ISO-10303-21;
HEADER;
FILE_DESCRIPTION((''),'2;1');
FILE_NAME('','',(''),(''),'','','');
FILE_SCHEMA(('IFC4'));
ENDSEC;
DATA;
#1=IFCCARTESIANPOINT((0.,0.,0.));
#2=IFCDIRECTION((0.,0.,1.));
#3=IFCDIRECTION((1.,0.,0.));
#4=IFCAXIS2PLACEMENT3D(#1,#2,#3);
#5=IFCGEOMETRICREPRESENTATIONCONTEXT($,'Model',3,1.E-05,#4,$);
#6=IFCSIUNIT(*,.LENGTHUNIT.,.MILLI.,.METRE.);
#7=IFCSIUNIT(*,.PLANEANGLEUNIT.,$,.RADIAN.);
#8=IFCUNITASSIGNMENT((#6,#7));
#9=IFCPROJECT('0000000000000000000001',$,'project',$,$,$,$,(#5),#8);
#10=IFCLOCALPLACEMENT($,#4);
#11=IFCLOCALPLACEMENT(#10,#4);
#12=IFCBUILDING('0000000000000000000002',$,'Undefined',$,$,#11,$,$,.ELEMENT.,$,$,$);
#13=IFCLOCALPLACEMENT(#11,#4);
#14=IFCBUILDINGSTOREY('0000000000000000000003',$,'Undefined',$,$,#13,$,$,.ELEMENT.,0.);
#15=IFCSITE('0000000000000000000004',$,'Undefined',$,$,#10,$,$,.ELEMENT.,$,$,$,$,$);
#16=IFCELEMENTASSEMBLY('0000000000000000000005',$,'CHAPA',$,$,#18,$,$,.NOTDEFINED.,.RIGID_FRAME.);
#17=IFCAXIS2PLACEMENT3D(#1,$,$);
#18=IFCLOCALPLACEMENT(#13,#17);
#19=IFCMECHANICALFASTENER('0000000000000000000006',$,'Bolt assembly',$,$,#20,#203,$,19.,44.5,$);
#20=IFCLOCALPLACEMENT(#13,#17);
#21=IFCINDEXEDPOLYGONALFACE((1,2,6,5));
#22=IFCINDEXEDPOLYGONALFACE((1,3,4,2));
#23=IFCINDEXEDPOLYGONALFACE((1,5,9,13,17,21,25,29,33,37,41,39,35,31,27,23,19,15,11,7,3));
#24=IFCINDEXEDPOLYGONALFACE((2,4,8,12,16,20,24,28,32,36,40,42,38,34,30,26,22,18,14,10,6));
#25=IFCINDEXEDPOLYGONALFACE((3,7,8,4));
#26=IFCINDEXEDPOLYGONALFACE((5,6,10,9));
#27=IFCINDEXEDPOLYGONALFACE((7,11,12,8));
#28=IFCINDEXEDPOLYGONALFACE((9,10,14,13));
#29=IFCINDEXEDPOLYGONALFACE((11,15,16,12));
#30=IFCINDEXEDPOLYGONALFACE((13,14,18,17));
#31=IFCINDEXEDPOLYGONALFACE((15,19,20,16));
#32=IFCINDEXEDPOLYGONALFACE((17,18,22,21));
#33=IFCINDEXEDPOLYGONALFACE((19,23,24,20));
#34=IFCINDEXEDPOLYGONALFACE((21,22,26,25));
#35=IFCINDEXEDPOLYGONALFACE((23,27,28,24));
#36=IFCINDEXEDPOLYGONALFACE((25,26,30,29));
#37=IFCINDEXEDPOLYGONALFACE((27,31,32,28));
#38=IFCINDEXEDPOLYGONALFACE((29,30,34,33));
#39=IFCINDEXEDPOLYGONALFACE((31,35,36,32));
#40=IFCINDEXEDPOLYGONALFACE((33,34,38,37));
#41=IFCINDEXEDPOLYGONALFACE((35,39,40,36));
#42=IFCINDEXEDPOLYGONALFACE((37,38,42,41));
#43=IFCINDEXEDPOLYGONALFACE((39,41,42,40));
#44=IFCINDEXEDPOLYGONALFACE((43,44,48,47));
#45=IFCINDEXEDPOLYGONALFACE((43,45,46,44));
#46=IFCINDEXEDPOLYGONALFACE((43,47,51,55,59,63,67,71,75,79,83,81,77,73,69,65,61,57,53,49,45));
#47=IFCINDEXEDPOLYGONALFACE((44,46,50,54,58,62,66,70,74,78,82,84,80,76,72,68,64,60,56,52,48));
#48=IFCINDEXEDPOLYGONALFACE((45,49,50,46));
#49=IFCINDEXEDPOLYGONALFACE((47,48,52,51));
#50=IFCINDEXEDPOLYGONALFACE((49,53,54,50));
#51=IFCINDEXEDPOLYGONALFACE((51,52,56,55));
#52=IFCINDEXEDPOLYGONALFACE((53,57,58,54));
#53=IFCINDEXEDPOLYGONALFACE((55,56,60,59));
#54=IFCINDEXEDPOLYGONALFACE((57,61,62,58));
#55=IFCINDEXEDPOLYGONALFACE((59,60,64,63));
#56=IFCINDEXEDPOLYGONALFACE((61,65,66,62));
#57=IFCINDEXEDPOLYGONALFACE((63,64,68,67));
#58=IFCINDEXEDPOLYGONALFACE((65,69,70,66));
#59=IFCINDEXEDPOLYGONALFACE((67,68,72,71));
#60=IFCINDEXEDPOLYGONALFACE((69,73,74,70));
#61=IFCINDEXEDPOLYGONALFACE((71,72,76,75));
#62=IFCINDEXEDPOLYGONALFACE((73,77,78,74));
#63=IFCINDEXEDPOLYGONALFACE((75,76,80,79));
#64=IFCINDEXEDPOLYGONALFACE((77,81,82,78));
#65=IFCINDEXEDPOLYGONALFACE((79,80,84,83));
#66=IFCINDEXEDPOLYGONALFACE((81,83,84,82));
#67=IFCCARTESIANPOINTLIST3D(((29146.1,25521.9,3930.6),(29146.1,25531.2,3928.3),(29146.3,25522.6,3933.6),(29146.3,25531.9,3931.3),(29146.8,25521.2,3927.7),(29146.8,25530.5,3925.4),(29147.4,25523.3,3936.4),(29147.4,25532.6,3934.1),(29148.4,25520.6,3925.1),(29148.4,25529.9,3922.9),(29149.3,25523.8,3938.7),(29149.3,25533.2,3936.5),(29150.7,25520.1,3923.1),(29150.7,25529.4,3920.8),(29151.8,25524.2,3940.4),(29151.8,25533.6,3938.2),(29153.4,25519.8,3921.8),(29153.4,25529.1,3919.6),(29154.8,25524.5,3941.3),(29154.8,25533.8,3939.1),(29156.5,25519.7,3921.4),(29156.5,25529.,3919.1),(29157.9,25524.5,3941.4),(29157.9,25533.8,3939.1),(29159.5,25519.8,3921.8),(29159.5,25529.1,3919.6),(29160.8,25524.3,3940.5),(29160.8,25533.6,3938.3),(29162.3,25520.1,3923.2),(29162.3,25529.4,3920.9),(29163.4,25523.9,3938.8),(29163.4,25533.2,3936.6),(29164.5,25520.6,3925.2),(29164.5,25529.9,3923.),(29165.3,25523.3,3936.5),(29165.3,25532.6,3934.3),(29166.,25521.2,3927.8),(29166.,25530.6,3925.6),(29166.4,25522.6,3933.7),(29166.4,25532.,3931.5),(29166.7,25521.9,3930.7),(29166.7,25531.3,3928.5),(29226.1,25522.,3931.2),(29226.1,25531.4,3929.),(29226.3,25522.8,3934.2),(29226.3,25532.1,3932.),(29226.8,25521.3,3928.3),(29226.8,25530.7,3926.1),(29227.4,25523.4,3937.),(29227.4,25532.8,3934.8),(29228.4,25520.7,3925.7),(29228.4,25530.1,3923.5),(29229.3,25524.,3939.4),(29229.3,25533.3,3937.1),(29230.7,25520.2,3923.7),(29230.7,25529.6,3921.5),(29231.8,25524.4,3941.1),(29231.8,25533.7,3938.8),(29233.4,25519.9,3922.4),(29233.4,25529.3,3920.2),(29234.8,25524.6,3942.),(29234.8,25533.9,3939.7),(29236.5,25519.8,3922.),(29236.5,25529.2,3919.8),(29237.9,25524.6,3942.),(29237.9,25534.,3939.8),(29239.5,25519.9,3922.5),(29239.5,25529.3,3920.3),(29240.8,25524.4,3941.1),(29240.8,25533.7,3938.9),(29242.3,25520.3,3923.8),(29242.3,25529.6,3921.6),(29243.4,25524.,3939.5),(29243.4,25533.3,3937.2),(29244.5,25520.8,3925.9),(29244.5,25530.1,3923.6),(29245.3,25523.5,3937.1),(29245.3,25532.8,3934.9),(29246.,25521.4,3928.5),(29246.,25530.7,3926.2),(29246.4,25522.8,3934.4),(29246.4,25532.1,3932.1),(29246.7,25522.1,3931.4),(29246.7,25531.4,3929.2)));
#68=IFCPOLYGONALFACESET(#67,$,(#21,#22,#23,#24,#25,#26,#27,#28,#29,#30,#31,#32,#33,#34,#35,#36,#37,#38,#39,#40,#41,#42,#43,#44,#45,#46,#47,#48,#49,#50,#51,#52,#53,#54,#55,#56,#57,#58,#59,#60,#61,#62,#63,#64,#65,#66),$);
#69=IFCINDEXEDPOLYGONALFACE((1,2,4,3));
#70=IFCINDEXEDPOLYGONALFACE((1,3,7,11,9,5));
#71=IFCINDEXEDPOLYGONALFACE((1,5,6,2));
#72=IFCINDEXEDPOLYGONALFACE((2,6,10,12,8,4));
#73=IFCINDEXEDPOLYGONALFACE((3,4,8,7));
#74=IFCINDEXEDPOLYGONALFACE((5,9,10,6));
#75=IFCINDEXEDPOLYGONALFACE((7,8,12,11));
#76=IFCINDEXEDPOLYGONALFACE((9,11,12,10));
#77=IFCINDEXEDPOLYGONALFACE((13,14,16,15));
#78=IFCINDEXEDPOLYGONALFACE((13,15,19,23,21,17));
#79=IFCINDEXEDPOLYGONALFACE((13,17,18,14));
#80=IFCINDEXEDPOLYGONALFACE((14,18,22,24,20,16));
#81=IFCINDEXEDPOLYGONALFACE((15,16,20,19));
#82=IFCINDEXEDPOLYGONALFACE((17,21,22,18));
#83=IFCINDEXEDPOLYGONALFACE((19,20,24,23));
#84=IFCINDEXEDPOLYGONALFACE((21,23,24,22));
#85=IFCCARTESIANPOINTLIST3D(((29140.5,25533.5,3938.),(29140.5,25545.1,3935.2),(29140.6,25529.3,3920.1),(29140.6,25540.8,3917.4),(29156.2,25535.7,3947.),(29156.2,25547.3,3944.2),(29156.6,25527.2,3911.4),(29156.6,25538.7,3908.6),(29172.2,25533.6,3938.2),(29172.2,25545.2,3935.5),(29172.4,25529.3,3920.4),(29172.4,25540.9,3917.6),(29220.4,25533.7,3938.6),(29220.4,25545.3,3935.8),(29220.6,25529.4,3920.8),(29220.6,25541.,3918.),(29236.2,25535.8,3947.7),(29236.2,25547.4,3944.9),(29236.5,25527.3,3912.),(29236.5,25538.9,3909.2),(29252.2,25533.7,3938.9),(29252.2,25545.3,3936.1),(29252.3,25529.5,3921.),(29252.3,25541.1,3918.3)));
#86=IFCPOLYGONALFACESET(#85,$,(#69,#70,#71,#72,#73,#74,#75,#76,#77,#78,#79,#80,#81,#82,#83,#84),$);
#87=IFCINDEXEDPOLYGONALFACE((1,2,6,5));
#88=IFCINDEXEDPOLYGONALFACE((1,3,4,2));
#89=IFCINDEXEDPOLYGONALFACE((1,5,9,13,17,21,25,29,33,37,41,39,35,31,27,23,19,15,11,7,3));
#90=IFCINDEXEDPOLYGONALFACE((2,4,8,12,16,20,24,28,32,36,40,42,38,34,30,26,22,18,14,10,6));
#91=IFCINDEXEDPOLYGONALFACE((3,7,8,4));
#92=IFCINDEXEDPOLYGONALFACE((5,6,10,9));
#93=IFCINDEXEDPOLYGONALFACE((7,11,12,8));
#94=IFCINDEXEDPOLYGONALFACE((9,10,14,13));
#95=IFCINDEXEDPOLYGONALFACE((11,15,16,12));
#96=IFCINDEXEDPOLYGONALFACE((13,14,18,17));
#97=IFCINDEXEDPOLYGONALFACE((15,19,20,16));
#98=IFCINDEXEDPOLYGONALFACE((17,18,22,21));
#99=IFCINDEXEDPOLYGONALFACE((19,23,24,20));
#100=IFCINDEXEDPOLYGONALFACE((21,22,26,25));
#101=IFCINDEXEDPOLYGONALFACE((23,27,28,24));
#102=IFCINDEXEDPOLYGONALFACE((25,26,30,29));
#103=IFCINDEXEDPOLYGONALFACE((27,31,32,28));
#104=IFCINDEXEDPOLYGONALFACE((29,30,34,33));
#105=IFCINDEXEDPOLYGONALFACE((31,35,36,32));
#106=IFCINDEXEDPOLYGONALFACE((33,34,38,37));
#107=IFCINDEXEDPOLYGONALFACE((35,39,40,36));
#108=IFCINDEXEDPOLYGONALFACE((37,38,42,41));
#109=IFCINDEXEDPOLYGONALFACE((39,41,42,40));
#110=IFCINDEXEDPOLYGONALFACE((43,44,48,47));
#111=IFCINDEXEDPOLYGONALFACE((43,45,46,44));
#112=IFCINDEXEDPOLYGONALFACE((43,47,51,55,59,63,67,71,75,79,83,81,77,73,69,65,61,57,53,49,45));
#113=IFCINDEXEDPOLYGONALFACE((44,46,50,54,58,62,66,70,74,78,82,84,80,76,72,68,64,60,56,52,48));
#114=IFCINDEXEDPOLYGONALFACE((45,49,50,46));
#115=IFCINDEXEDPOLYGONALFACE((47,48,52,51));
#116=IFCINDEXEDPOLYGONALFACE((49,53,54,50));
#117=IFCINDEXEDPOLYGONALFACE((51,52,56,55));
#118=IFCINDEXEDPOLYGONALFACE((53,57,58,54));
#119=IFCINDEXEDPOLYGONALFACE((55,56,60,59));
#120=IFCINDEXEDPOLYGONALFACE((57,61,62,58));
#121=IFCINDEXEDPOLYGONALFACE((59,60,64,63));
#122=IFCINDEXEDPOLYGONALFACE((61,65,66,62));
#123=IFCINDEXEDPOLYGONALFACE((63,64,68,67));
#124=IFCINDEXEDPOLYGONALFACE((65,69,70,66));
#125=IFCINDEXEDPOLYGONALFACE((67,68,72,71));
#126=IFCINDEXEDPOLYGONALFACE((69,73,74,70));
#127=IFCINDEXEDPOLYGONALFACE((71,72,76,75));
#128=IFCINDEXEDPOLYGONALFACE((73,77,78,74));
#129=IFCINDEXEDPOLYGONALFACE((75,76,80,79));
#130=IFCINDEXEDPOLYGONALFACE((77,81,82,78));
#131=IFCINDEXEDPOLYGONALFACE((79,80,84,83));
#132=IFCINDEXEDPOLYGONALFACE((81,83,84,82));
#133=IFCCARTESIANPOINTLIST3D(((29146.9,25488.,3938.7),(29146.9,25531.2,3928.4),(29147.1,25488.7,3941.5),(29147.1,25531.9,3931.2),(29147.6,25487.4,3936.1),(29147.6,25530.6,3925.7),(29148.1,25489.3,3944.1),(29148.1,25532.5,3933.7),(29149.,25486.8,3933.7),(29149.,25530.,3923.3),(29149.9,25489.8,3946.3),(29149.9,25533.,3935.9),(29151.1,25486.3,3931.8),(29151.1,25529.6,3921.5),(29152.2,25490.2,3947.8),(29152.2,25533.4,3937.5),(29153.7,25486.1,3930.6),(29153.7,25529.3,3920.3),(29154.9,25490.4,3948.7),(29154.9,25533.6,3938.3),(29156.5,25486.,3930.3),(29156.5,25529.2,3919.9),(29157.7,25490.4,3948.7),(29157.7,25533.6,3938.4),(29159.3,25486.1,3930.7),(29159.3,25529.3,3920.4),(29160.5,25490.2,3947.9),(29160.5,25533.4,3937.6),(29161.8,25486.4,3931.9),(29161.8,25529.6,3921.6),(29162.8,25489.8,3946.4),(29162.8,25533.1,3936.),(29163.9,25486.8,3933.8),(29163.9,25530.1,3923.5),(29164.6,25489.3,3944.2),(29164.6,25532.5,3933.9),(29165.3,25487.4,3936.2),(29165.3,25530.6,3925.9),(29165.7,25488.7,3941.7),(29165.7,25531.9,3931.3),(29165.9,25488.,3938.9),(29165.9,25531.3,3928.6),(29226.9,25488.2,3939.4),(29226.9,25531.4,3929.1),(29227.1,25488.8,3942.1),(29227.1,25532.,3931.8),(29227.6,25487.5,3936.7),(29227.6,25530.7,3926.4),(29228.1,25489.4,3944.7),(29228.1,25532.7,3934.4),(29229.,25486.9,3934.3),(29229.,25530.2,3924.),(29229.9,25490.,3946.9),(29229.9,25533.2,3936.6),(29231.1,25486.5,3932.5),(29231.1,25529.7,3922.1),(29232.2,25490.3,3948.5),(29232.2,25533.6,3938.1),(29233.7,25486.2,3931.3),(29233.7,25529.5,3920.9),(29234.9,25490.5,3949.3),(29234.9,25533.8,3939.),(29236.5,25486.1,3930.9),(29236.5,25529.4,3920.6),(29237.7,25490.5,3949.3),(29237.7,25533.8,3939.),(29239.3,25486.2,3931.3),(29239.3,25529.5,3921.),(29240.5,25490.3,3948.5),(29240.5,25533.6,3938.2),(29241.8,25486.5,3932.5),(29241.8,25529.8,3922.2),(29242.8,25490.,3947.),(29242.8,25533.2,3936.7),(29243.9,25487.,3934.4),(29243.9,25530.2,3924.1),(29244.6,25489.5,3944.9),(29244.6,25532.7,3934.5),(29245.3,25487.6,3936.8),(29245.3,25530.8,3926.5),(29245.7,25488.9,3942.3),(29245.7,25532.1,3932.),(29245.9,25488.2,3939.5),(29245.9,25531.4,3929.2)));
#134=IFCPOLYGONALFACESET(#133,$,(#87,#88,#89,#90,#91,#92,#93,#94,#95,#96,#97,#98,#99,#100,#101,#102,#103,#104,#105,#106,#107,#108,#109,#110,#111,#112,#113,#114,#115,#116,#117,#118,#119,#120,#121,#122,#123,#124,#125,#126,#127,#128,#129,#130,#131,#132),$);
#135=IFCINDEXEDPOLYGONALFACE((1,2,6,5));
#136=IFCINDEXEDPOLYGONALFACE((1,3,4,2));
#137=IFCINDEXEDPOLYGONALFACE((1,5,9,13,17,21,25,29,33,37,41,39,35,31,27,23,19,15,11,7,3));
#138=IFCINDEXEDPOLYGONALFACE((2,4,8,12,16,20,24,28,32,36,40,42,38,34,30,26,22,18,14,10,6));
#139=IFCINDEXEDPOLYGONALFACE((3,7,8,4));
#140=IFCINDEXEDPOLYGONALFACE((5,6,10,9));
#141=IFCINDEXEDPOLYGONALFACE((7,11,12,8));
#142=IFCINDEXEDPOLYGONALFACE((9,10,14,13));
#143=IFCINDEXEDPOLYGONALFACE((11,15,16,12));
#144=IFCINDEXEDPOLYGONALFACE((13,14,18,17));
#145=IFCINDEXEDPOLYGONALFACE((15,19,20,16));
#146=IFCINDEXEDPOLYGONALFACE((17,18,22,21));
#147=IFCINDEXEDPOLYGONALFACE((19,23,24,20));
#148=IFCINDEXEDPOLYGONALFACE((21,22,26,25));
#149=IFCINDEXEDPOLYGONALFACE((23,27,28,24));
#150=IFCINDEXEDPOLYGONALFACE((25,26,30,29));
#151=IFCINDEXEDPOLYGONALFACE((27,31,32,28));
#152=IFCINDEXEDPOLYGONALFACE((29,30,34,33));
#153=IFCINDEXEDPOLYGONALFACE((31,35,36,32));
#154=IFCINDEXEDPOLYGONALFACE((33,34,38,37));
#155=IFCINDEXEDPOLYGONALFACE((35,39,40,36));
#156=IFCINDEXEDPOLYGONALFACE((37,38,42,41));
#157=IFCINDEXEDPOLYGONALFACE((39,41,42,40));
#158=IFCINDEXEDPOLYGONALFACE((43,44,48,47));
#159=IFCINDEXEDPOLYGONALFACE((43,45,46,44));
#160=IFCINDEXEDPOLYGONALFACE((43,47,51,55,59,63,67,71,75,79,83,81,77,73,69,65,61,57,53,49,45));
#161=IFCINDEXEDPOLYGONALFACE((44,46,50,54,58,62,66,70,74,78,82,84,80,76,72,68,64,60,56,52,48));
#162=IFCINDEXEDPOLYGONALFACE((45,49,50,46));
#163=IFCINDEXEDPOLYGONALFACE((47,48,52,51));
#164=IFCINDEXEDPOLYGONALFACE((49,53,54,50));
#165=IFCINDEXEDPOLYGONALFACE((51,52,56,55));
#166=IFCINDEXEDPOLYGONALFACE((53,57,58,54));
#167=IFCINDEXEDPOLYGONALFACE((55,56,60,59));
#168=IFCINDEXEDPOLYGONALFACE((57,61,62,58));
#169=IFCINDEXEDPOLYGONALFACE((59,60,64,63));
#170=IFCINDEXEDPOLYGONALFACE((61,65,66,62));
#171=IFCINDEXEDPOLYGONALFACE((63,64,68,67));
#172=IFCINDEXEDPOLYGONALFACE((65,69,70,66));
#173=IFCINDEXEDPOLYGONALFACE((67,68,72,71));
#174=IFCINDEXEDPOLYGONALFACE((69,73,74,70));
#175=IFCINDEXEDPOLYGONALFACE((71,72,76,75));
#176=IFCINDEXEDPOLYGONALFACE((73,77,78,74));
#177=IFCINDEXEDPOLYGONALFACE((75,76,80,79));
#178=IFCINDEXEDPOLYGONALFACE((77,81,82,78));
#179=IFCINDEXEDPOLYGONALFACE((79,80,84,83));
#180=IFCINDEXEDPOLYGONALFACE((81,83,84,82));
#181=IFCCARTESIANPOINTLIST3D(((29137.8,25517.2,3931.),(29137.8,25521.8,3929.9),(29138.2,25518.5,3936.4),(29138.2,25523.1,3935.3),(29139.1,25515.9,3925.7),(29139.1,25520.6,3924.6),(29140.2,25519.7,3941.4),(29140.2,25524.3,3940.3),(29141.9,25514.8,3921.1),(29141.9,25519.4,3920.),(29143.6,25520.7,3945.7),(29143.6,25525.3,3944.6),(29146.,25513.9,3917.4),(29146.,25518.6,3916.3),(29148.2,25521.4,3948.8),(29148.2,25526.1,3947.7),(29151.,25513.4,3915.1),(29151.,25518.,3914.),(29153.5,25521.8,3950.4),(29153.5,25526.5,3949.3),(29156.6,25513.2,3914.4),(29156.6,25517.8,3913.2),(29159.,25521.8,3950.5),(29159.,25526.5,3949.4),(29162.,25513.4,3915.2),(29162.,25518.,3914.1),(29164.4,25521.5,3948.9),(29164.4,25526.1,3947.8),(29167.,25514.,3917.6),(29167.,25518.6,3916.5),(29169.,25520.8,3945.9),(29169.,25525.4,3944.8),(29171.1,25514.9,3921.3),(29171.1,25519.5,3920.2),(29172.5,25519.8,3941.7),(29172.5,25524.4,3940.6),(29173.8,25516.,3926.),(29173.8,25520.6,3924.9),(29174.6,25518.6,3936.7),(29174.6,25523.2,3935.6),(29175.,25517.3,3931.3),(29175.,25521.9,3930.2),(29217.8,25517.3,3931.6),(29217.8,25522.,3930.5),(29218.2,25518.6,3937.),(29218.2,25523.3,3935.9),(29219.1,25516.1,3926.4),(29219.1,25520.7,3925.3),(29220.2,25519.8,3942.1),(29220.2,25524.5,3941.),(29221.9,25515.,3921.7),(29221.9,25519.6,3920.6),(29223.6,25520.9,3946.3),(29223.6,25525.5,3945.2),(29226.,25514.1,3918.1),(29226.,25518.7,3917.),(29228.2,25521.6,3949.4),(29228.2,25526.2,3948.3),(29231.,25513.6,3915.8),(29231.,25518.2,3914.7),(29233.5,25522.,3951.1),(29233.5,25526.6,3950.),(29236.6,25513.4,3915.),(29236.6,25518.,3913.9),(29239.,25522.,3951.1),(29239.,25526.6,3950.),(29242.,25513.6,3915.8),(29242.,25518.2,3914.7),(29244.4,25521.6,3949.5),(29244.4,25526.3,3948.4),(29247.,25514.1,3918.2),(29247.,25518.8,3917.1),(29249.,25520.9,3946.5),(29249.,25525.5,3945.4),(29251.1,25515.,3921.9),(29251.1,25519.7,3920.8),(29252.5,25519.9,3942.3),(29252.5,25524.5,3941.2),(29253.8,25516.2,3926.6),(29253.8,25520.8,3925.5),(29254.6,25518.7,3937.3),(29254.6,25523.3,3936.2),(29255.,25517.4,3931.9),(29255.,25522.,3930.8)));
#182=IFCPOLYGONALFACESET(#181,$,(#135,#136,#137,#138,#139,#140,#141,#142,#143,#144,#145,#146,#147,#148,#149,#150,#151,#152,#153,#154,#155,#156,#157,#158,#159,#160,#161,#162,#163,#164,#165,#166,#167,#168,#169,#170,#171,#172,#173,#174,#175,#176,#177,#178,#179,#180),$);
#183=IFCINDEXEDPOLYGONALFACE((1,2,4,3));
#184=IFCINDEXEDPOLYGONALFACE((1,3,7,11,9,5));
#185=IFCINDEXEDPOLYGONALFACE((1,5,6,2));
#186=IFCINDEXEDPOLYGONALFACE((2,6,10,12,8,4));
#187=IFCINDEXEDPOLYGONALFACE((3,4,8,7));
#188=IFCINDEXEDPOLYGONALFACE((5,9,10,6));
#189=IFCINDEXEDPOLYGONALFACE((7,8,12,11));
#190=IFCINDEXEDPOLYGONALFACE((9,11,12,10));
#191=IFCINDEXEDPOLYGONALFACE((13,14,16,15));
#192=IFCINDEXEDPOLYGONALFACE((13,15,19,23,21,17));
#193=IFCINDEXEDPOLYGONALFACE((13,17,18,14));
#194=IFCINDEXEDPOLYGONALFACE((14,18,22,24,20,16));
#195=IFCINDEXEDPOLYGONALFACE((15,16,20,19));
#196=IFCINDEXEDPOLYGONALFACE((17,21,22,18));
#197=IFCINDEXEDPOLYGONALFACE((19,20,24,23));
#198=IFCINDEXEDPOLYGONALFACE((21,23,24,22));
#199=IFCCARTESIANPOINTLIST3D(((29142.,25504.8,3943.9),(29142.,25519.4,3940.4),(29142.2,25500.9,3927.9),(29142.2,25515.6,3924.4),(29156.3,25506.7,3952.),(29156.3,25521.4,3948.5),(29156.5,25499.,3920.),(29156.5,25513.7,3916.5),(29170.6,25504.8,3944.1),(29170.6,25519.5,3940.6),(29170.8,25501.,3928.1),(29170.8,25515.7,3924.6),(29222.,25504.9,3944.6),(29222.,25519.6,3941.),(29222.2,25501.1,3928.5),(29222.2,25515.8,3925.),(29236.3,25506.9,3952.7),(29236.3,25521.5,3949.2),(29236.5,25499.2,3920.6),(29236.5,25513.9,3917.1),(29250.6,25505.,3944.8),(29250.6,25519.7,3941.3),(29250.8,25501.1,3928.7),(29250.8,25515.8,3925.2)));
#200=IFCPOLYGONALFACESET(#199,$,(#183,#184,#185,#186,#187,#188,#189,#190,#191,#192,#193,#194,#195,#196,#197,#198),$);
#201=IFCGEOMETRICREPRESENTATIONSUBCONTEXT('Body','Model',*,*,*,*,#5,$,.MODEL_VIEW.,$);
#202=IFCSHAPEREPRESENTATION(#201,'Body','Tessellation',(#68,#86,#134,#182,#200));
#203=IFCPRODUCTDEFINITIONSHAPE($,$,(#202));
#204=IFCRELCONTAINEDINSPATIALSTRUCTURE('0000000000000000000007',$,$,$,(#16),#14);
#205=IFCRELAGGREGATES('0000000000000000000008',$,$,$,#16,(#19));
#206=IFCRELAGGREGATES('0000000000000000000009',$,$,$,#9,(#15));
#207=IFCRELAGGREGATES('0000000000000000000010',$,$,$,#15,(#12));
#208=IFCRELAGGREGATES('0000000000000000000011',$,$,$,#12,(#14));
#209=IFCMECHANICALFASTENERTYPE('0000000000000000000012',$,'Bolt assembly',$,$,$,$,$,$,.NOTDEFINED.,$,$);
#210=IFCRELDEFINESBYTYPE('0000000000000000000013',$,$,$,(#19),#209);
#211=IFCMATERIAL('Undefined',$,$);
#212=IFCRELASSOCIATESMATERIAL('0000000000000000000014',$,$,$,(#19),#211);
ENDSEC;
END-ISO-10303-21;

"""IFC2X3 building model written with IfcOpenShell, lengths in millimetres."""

from ifc_helpers import new_model, si_unit, frame, origin_with_axes, origin_2d_with_axis, place, context, subcontext, project, spatial, polyline, circle, outline, extrude, source, transform, mapped, material, type_object, element, aggregate, save


model = new_model("IFC2X3")

# Units and contexts
model_context = context("Model", 3, precision=1e-05, world=origin_with_axes())
body_context = subcontext(model_context, "Body", "Model", "MODEL_VIEW")
ifc_project = project(units=[si_unit("LENGTHUNIT", "METRE", prefix="MILLI"), si_unit("PLANEANGLEUNIT", "RADIAN")], contexts=[model_context])

# Site, building, storey
site_placement = place(None, origin_with_axes())
site = spatial("IfcSite", under=ifc_project, at=site_placement, Name="Undefined", CompositionType="ELEMENT")
building_placement = place(site_placement, origin_with_axes())
building = spatial("IfcBuilding", under=site, at=building_placement, Name="Undefined", CompositionType="ELEMENT")
storey_placement = place(building_placement, origin_with_axes())
storey = spatial("IfcBuildingStorey", under=building, at=storey_placement, Name="Undefined", CompositionType="ELEMENT", Elevation=0.0)

# Element assembly
assembly_1_placement = place(storey_placement, origin_with_axes())
assembly_1 = element("IfcElementAssembly", 1, at=assembly_1_placement, inside=storey, Name="CHAPA", AssemblyPlace="NOTDEFINED", PredefinedType="RIGID_FRAME")

# Shared definitions
ifc_material_1 = material(Name="Undefined")
mechanical_fastener_type = type_object("IfcMechanicalFastenerType", Name="Bolt assembly")

# Mechanical fastener
shared_shape_1 = source(origin_with_axes(), body_context, "Body", "SweptSolid", [
    extrude(circle(Radius=10.3, at=origin_2d_with_axis()), frame((0.0, 0.0, 0.0), z_axis=(0.0, 1.0, 0.0), x_axis=(1.0, 0.0, 0.0)), (0.0, 0.0, 1.0), 9.6),
    extrude(outline(polyline([(18.3, 0.0), (9.2, 15.9), (-9.2, 15.9), (-18.3, 0.0), (-9.2, -15.9), (9.2, -15.9), (18.3, 0.0)])), frame((0.0, -11.9, 0.0), z_axis=(0.0, 1.0, 0.0), x_axis=(1.0, 0.0, 0.0)), (0.0, 0.0, 1.0), 11.9),
    extrude(circle(Radius=9.5, at=origin_2d_with_axis()), frame((0.0, 0.0, 0.0), z_axis=(0.0, 1.0, 0.0), x_axis=(1.0, 0.0, 0.0)), (0.0, 0.0, 1.0), 44.5),
    extrude(circle(Radius=18.7, at=origin_2d_with_axis()), frame((0.0, 9.5, 0.0), z_axis=(0.0, 1.0, 0.0), x_axis=(1.0, 0.0, 0.0)), (0.0, 0.0, 1.0), 4.8),
    extrude(outline(polyline([(16.5, 0.0), (8.2, 14.3), (-8.2, 14.3), (-16.5, 0.0), (-8.2, -14.3), (8.2, -14.3), (16.5, 0.0)])), frame((0.0, 14.3, 0.0), z_axis=(0.0, 1.0, 0.0), x_axis=(1.0, 0.0, 0.0)), (0.0, 0.0, 1.0), 15.1),
])
mechanical_fastener_1_placement = place(assembly_1_placement, frame((29196.4, 25531.5, 3929.5), z_axis=(-0.999966, -0.001919, -0.008026), x_axis=(0.008253, -0.23249, -0.972564)))
mechanical_fastener_1 = element("IfcMechanicalFastener", 2, at=mechanical_fastener_1_placement, type_object=mechanical_fastener_type, material=ifc_material_1, Name="Bolt assembly", NominalDiameter=19.0, NominalLength=44.5, context=body_context, shape_type="MappedRepresentation", body=[
    mapped(shared_shape_1, transform((0.0, 0.0, 40.0))),
    mapped(shared_shape_1, transform((0.0, 0.0, -40.0))),
])
aggregate(assembly_1, [mechanical_fastener_1])

save(model, "model.ifc")
